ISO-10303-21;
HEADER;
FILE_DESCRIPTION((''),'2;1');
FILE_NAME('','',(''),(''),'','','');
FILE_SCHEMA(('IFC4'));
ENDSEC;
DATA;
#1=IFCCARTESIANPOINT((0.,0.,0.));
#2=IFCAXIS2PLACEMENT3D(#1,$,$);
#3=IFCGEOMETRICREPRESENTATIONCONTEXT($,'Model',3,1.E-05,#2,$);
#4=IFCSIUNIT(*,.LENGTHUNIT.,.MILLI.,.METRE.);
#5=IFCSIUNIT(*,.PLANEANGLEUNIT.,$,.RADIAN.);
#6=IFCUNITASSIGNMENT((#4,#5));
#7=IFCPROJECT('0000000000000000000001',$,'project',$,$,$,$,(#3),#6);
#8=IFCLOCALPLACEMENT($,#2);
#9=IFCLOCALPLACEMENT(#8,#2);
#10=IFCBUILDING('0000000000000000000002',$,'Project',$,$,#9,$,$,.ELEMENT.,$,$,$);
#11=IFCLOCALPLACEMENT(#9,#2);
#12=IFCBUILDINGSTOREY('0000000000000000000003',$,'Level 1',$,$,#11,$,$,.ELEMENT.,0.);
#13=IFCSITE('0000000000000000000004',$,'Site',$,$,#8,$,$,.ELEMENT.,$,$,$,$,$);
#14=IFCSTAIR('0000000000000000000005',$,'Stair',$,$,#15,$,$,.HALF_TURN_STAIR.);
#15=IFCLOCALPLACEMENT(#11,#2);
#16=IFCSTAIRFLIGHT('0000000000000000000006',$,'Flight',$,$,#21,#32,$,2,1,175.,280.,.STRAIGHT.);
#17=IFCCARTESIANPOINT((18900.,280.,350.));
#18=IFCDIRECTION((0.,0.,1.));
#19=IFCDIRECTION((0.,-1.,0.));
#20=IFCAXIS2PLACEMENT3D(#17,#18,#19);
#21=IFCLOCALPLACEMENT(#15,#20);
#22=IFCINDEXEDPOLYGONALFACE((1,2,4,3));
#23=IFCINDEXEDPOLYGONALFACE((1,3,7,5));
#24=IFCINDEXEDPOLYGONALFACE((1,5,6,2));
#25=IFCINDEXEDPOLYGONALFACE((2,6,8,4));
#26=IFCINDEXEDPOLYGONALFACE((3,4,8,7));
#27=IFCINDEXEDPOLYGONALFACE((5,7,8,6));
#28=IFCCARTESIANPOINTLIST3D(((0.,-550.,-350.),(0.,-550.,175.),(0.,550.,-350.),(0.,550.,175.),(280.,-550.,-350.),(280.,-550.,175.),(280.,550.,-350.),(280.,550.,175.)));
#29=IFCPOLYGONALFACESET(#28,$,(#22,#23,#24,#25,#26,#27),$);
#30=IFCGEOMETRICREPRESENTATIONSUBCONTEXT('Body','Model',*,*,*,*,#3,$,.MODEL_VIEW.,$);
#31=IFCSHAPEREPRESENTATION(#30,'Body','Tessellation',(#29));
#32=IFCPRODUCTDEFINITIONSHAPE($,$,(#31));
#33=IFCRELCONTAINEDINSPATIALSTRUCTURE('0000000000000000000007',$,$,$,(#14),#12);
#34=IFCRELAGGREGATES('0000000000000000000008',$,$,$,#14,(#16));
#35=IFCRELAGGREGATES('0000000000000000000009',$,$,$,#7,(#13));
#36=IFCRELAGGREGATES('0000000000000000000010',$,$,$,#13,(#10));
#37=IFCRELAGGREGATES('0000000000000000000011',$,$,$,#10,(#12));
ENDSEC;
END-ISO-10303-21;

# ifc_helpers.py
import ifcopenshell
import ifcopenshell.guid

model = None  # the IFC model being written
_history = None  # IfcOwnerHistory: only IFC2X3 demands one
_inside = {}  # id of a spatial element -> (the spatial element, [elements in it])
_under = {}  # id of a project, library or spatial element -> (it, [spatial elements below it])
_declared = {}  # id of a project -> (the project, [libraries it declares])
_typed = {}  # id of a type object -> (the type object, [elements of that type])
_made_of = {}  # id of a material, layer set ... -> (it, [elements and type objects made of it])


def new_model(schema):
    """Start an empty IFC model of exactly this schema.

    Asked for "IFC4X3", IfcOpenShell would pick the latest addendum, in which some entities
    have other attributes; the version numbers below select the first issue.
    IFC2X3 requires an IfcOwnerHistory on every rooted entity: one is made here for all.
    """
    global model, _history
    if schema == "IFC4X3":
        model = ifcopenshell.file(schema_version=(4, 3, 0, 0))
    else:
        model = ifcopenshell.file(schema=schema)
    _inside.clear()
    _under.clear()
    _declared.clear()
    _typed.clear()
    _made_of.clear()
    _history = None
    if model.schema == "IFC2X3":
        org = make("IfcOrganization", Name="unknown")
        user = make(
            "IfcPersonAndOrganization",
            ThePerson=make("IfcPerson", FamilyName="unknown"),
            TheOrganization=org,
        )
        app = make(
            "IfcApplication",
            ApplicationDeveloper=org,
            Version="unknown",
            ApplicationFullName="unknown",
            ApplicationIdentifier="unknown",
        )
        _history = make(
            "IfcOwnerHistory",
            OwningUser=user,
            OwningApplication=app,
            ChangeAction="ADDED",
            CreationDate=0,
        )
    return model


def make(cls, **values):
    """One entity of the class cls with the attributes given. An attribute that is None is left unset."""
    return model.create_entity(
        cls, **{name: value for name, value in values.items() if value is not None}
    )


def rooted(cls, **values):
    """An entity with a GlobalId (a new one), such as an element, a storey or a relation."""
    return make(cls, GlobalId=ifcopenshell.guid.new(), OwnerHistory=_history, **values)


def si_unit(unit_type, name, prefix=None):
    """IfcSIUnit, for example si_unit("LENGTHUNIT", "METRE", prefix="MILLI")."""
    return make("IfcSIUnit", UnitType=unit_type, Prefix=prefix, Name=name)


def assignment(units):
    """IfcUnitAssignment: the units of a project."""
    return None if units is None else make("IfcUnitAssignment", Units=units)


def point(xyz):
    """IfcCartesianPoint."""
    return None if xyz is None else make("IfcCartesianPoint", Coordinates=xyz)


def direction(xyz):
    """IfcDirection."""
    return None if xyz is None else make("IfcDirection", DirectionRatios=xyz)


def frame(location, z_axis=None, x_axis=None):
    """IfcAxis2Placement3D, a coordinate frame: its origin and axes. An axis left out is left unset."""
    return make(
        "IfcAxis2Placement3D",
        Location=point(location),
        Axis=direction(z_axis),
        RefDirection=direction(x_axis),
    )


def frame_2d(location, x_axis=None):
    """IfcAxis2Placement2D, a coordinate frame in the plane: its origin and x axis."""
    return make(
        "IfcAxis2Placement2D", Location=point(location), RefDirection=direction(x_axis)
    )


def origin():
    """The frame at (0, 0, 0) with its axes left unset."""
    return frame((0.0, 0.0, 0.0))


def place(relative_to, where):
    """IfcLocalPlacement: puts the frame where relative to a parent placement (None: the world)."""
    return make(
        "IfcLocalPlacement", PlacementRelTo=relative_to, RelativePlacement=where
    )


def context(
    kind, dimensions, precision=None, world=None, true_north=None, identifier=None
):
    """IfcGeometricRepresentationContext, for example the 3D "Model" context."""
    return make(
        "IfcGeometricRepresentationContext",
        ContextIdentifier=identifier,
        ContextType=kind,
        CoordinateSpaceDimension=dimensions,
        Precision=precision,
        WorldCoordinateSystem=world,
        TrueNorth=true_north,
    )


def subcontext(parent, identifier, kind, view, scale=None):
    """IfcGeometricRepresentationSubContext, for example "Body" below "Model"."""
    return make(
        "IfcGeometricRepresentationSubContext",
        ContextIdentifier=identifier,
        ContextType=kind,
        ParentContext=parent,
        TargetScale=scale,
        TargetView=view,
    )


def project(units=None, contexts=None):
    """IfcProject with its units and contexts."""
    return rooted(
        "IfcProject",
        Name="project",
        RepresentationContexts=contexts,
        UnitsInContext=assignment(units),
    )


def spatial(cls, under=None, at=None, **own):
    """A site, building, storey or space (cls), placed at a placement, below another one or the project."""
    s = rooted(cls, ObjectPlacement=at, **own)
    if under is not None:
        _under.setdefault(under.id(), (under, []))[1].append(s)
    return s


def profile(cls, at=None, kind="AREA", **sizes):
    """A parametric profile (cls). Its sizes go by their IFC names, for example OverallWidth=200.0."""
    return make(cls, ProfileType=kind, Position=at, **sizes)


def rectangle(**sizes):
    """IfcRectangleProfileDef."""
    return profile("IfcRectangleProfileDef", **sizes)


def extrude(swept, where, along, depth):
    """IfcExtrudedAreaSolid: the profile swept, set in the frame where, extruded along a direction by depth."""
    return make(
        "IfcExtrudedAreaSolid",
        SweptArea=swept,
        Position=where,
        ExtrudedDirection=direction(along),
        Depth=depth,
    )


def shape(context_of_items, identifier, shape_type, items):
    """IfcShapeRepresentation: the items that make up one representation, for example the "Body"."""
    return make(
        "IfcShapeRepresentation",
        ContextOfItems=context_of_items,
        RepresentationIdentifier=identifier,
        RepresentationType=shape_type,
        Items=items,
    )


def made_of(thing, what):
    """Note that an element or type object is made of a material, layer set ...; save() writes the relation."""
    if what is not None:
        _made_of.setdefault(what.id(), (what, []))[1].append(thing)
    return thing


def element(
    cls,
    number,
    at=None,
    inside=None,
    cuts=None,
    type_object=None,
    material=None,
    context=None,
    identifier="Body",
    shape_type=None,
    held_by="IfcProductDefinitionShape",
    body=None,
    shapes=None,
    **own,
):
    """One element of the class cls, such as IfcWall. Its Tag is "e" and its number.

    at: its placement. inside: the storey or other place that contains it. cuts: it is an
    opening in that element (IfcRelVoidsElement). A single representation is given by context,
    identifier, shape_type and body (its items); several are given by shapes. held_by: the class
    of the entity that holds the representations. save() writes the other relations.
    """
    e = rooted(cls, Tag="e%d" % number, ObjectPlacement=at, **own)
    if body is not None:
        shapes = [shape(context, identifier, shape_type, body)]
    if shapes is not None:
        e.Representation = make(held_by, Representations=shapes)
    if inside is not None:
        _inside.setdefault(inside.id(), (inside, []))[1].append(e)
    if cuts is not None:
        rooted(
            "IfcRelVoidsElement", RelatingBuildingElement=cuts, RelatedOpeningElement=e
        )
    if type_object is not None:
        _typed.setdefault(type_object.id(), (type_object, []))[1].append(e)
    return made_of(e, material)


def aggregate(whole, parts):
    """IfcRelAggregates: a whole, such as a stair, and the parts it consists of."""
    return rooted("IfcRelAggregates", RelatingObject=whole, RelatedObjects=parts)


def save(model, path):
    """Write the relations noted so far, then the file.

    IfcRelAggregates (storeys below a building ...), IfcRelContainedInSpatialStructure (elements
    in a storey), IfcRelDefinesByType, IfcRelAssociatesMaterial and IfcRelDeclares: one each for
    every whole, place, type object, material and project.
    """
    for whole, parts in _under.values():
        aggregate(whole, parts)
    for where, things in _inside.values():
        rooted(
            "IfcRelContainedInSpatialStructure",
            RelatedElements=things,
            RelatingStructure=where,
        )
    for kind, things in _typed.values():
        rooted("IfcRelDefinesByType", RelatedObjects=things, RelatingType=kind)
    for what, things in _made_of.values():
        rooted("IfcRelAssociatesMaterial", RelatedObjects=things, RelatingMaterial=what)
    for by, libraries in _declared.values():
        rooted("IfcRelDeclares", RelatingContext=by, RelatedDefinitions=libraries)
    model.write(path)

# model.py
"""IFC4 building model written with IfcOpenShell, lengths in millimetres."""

from ifc_helpers import new_model, si_unit, frame, frame_2d, origin, place, context, subcontext, project, spatial, rectangle, extrude, element, aggregate, save


model = new_model("IFC4")

# Units and contexts
model_context = context("Model", 3, precision=1e-05, world=origin())
body_context = subcontext(model_context, "Body", "Model", "MODEL_VIEW")
ifc_project = project(units=[si_unit("LENGTHUNIT", "METRE", prefix="MILLI"), si_unit("PLANEANGLEUNIT", "RADIAN")], contexts=[model_context])

# Site, building, storey
site_placement = place(None, origin())
site = spatial("IfcSite", under=ifc_project, at=site_placement, Name="Site", CompositionType="ELEMENT")
building_placement = place(site_placement, origin())
building = spatial("IfcBuilding", under=site, at=building_placement, Name="Project", CompositionType="ELEMENT")
storey_placement = place(building_placement, origin())
storey = spatial("IfcBuildingStorey", under=building, at=storey_placement, Name="Level 1", CompositionType="ELEMENT", Elevation=0.0)

# Stair
stair_placement = place(storey_placement, origin())
stair = element("IfcStair", 1, at=stair_placement, inside=storey, Name="Stair", PredefinedType="HALF_TURN_STAIR")

# Stair flight
stair_flight_1_placement = place(stair_placement, frame((18900.0, 280.0, 350.0), z_axis=(0.0, 0.0, 1.0), x_axis=(0.0, -1.0, 0.0)))
stair_flight_1 = element("IfcStairFlight", 2, at=stair_flight_1_placement, Name="Flight", NumberOfRisers=2, NumberOfTreads=1, PredefinedType="STRAIGHT", RiserHeight=175.0, TreadLength=280.0, context=body_context, shape_type="SweptSolid", body=[
    extrude(rectangle(XDim=280.0, YDim=1100.0, at=frame_2d((140.0, 0.0))), frame((0.0, 0.0, -350.0)), (0.0, 0.0, 1.0), 525.0),
])
aggregate(stair, [stair_flight_1])

save(model, "model.ifc")
